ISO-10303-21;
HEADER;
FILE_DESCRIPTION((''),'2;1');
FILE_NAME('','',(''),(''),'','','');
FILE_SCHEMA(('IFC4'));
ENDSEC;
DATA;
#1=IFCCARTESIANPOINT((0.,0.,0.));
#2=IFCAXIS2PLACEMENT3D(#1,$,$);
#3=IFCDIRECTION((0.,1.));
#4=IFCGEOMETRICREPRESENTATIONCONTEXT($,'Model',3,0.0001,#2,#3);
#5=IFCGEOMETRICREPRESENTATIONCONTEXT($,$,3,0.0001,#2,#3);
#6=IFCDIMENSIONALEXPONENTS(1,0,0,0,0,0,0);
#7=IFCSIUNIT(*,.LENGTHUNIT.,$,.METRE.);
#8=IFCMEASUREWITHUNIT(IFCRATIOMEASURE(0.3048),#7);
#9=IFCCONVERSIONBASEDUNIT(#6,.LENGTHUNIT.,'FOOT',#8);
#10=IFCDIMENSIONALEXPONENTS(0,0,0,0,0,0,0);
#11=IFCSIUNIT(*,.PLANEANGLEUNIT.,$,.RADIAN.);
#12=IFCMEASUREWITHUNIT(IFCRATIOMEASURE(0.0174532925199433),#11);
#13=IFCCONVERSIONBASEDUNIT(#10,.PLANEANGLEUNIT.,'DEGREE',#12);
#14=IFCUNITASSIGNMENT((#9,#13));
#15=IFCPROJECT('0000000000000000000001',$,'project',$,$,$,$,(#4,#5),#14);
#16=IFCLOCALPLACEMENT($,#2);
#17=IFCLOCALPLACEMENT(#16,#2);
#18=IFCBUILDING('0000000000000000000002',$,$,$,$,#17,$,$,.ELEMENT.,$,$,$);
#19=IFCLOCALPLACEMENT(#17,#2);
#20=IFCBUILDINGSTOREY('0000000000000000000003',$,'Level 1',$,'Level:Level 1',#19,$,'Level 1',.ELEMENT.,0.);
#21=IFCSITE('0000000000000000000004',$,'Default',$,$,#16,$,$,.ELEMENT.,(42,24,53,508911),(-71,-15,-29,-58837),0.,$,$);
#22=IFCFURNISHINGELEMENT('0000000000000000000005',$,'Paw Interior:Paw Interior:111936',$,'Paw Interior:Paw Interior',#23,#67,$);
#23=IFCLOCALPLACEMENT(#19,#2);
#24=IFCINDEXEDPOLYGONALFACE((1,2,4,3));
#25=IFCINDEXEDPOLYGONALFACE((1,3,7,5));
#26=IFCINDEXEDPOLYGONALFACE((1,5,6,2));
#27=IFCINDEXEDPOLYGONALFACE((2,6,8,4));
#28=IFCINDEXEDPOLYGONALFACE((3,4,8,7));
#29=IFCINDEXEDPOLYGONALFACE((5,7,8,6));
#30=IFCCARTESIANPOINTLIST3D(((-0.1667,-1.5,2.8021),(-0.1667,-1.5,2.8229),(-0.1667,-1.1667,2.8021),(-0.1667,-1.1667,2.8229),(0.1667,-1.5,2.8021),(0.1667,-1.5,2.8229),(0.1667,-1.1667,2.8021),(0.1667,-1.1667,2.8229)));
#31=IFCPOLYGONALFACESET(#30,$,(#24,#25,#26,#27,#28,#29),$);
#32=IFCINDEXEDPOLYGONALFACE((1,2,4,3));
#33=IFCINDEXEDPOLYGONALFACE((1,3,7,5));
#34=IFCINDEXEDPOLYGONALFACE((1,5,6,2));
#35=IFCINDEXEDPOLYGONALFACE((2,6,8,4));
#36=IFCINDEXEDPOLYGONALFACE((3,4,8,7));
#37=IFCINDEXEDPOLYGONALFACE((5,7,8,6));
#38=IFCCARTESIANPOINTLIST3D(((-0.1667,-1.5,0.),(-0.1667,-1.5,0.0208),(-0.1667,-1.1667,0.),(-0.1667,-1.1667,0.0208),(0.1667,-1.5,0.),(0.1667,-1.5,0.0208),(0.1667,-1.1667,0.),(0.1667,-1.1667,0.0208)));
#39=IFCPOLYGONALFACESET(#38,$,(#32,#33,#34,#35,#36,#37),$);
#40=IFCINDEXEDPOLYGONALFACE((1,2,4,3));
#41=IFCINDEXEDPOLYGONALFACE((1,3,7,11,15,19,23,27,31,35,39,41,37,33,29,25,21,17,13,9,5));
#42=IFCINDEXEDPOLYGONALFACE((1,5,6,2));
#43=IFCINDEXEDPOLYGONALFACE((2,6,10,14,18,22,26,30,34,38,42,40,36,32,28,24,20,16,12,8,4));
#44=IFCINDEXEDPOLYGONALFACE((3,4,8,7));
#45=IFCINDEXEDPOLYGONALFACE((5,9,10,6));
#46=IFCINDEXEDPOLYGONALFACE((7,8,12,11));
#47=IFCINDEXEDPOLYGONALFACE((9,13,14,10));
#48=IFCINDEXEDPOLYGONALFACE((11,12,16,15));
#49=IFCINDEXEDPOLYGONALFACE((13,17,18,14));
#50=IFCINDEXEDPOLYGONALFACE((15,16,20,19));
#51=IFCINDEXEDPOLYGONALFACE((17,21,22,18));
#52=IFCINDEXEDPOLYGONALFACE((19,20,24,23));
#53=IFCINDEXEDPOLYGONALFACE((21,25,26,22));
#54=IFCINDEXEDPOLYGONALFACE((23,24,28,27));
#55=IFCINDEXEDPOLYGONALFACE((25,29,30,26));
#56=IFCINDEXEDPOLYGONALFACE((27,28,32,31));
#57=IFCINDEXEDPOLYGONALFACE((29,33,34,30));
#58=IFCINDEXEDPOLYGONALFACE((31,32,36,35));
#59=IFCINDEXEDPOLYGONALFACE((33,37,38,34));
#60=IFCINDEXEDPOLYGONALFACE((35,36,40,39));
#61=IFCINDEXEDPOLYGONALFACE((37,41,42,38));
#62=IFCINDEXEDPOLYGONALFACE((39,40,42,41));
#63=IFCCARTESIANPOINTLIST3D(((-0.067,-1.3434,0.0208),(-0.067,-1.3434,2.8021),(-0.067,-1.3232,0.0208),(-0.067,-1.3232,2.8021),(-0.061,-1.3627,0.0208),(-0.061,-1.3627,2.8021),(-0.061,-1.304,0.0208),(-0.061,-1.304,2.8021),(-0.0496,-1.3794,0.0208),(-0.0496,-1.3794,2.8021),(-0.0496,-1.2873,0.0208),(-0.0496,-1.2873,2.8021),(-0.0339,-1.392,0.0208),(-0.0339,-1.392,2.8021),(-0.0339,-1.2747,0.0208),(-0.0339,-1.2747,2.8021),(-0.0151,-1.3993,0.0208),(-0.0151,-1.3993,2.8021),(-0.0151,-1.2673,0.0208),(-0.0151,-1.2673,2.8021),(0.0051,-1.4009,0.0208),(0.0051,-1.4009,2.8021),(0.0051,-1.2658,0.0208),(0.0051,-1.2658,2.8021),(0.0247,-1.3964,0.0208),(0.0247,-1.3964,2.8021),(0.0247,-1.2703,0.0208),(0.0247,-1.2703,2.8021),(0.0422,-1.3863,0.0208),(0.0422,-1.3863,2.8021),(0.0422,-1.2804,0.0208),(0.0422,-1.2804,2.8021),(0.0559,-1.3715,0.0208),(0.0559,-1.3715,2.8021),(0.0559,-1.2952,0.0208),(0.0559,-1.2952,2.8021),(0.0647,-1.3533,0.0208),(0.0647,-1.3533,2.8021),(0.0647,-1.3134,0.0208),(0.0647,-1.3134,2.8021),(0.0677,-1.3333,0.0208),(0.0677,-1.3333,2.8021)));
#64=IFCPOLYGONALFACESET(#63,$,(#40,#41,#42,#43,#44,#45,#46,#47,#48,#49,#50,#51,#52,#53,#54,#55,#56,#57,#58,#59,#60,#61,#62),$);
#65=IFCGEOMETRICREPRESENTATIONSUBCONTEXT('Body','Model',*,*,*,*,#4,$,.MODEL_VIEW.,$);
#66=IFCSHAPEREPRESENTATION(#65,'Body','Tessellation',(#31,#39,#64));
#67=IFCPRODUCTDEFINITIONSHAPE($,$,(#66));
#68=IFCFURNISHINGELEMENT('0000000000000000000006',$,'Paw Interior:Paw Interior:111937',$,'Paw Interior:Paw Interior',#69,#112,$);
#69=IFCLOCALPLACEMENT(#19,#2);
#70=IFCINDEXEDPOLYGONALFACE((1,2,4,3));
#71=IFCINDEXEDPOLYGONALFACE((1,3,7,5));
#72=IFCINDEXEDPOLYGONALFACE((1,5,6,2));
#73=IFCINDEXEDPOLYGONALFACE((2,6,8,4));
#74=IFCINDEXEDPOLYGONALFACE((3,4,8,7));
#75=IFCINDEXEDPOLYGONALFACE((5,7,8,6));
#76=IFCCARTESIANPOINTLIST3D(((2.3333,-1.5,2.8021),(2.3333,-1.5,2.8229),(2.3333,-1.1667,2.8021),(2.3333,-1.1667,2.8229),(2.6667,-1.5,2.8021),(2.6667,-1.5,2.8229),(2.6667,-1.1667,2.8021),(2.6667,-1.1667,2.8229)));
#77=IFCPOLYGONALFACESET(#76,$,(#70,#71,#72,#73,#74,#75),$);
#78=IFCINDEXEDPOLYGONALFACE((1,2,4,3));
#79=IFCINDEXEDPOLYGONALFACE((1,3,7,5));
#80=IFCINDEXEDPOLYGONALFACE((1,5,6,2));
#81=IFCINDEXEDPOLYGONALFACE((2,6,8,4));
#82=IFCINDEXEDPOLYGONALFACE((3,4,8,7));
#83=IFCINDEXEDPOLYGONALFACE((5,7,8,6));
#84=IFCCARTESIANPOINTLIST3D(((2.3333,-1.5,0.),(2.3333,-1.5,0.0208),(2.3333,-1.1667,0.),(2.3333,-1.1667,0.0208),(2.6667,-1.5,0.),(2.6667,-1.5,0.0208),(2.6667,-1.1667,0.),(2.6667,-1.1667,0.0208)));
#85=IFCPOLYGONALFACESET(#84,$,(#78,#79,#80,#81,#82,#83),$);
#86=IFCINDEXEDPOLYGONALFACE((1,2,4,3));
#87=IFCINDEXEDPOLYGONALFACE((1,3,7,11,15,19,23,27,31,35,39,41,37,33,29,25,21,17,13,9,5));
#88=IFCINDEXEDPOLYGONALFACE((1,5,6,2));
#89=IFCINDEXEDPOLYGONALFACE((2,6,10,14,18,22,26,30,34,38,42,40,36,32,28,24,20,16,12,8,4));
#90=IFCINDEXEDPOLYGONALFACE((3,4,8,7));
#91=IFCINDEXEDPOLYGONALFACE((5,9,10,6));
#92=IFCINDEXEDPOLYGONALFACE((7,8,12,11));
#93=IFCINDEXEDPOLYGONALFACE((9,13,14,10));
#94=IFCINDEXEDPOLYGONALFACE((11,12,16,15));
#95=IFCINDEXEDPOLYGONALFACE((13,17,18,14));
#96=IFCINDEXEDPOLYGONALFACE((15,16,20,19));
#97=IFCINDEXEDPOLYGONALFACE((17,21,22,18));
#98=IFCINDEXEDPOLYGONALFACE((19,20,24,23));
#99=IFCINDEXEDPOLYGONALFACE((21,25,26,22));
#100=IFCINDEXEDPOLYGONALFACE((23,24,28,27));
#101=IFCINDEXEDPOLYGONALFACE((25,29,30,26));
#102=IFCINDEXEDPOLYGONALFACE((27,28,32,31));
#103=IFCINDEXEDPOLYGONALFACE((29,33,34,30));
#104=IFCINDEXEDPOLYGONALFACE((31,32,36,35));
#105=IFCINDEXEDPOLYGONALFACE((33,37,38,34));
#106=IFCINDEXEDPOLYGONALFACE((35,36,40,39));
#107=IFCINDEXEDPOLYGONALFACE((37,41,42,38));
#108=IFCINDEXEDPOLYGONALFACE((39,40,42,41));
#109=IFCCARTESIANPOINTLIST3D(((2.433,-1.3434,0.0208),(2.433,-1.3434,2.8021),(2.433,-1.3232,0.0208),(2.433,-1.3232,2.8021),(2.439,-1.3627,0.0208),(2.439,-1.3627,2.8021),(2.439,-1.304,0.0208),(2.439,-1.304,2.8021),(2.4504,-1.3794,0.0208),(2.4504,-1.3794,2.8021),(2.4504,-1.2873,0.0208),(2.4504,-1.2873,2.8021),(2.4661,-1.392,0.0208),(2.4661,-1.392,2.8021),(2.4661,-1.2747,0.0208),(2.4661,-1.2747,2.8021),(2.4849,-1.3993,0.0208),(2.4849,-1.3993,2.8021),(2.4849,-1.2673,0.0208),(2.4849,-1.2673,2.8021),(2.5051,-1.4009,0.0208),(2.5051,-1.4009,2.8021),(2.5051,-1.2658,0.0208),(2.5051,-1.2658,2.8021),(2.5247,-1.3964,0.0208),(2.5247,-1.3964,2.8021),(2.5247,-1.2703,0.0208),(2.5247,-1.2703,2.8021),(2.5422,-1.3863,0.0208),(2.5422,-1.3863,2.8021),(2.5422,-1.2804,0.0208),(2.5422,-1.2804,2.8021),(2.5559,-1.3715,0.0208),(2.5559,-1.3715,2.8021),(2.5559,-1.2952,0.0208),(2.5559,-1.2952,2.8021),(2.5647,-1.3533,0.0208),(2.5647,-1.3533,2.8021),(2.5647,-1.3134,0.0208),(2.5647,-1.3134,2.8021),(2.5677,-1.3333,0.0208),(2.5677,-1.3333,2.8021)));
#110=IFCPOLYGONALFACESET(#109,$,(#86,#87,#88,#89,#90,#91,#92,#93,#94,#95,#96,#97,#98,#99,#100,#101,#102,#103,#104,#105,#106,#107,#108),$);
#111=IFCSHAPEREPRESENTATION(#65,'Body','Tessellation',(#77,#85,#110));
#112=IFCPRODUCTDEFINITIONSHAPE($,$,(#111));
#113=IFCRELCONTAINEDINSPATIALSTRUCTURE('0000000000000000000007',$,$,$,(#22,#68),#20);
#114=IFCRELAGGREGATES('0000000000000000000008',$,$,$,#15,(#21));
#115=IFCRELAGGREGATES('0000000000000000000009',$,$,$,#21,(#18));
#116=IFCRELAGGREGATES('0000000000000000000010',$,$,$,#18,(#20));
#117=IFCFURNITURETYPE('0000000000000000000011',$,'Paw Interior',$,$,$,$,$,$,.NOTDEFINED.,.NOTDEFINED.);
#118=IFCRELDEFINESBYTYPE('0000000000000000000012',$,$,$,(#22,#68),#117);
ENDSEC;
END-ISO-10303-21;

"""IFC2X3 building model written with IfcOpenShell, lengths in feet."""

from ifc_helpers import new_model, entity, si_unit, converted_unit, direction, frame, frame_2d, origin, place, context, subcontext, project, spatial, rectangle, circle, extrude, source, transform, mapped, type_object, type_shapes, element, save


model = new_model("IFC2X3")

# Units and contexts
model_context = context("Model", 3, precision=0.0001, world=origin(), true_north=direction((0.0, 1.0)))
context_of_model = context(None, 3, precision=0.0001, world=origin(), true_north=direction((0.0, 1.0)))
body_context = subcontext(model_context, "Body", "Model", "MODEL_VIEW")
ifc_project = project(units=[converted_unit("LENGTHUNIT", "FOOT", entity("IfcRatioMeasure", 0.3048), si_unit("LENGTHUNIT", "METRE"), dimensions=[1, 0, 0, 0, 0, 0, 0]), converted_unit("PLANEANGLEUNIT", "DEGREE", entity("IfcRatioMeasure", 0.0174532925199433), si_unit("PLANEANGLEUNIT", "RADIAN"), dimensions=[0, 0, 0, 0, 0, 0, 0])], contexts=[model_context, context_of_model])

# Site, building, storey
site_placement = place(None, origin())
site = spatial("IfcSite", under=ifc_project, at=site_placement, Name="Default", CompositionType="ELEMENT", RefLatitude=(42, 24, 53, 508911), RefLongitude=(-71, -15, -29, -58837), RefElevation=0.0)
building_placement = place(site_placement, origin())
building = spatial("IfcBuilding", under=site, at=building_placement, CompositionType="ELEMENT")
storey_placement = place(building_placement, origin())
storey = spatial("IfcBuildingStorey", under=building, at=storey_placement, Name="Level 1", ObjectType="Level:Level 1", LongName="Level 1", CompositionType="ELEMENT", Elevation=0.0)

# Furnishing elements
furniture_type_1 = type_object("IfcFurnitureType", Name="Paw Interior")
shared_shape_1 = source(origin(), body_context, "Body", "SweptSolid", [
    extrude(rectangle(XDim=0.3333, YDim=0.3333, at=frame_2d((0.0, 0.0), x_axis=(1.0, 0.0))), frame((0.0, 0.0, 2.8021), z_axis=(0.0, 0.0, 1.0), x_axis=(-1.0, 0.0, 0.0)), (0.0, 0.0, 1.0), 0.0208),
    extrude(rectangle(XDim=0.3333, YDim=0.3333, at=frame_2d((0.0, 0.0), x_axis=(1.0, 0.0))), frame((0.0, 0.0, 0.0), z_axis=(0.0, 0.0, 1.0), x_axis=(-1.0, 0.0, 0.0)), (0.0, 0.0, 1.0), 0.0208),
    extrude(circle(Radius=0.0677, at=frame_2d((0.0, 0.0), x_axis=(1.0, 0.0))), frame((0.0, 0.0, 0.0208)), (0.0, 0.0, 1.0), 2.7812),
])
type_shapes(furniture_type_1, [shared_shape_1])
for number, where, name in (
    (1, (0.0, -1.3333, 0.0), "Paw Interior:Paw Interior:111936"),
    (2, (2.5, -1.3333, 0.0), "Paw Interior:Paw Interior:111937"),
):
    element("IfcFurnishingElement", number, at=place(storey_placement, frame(where)), inside=storey, type_object=furniture_type_1, Name=name, ObjectType="Paw Interior:Paw Interior", context=body_context, shape_type="MappedRepresentation", body=[
        mapped(shared_shape_1, transform((0.0, 0.0, 0.0), scale=1.0)),
    ])

save(model, "model.ifc")
